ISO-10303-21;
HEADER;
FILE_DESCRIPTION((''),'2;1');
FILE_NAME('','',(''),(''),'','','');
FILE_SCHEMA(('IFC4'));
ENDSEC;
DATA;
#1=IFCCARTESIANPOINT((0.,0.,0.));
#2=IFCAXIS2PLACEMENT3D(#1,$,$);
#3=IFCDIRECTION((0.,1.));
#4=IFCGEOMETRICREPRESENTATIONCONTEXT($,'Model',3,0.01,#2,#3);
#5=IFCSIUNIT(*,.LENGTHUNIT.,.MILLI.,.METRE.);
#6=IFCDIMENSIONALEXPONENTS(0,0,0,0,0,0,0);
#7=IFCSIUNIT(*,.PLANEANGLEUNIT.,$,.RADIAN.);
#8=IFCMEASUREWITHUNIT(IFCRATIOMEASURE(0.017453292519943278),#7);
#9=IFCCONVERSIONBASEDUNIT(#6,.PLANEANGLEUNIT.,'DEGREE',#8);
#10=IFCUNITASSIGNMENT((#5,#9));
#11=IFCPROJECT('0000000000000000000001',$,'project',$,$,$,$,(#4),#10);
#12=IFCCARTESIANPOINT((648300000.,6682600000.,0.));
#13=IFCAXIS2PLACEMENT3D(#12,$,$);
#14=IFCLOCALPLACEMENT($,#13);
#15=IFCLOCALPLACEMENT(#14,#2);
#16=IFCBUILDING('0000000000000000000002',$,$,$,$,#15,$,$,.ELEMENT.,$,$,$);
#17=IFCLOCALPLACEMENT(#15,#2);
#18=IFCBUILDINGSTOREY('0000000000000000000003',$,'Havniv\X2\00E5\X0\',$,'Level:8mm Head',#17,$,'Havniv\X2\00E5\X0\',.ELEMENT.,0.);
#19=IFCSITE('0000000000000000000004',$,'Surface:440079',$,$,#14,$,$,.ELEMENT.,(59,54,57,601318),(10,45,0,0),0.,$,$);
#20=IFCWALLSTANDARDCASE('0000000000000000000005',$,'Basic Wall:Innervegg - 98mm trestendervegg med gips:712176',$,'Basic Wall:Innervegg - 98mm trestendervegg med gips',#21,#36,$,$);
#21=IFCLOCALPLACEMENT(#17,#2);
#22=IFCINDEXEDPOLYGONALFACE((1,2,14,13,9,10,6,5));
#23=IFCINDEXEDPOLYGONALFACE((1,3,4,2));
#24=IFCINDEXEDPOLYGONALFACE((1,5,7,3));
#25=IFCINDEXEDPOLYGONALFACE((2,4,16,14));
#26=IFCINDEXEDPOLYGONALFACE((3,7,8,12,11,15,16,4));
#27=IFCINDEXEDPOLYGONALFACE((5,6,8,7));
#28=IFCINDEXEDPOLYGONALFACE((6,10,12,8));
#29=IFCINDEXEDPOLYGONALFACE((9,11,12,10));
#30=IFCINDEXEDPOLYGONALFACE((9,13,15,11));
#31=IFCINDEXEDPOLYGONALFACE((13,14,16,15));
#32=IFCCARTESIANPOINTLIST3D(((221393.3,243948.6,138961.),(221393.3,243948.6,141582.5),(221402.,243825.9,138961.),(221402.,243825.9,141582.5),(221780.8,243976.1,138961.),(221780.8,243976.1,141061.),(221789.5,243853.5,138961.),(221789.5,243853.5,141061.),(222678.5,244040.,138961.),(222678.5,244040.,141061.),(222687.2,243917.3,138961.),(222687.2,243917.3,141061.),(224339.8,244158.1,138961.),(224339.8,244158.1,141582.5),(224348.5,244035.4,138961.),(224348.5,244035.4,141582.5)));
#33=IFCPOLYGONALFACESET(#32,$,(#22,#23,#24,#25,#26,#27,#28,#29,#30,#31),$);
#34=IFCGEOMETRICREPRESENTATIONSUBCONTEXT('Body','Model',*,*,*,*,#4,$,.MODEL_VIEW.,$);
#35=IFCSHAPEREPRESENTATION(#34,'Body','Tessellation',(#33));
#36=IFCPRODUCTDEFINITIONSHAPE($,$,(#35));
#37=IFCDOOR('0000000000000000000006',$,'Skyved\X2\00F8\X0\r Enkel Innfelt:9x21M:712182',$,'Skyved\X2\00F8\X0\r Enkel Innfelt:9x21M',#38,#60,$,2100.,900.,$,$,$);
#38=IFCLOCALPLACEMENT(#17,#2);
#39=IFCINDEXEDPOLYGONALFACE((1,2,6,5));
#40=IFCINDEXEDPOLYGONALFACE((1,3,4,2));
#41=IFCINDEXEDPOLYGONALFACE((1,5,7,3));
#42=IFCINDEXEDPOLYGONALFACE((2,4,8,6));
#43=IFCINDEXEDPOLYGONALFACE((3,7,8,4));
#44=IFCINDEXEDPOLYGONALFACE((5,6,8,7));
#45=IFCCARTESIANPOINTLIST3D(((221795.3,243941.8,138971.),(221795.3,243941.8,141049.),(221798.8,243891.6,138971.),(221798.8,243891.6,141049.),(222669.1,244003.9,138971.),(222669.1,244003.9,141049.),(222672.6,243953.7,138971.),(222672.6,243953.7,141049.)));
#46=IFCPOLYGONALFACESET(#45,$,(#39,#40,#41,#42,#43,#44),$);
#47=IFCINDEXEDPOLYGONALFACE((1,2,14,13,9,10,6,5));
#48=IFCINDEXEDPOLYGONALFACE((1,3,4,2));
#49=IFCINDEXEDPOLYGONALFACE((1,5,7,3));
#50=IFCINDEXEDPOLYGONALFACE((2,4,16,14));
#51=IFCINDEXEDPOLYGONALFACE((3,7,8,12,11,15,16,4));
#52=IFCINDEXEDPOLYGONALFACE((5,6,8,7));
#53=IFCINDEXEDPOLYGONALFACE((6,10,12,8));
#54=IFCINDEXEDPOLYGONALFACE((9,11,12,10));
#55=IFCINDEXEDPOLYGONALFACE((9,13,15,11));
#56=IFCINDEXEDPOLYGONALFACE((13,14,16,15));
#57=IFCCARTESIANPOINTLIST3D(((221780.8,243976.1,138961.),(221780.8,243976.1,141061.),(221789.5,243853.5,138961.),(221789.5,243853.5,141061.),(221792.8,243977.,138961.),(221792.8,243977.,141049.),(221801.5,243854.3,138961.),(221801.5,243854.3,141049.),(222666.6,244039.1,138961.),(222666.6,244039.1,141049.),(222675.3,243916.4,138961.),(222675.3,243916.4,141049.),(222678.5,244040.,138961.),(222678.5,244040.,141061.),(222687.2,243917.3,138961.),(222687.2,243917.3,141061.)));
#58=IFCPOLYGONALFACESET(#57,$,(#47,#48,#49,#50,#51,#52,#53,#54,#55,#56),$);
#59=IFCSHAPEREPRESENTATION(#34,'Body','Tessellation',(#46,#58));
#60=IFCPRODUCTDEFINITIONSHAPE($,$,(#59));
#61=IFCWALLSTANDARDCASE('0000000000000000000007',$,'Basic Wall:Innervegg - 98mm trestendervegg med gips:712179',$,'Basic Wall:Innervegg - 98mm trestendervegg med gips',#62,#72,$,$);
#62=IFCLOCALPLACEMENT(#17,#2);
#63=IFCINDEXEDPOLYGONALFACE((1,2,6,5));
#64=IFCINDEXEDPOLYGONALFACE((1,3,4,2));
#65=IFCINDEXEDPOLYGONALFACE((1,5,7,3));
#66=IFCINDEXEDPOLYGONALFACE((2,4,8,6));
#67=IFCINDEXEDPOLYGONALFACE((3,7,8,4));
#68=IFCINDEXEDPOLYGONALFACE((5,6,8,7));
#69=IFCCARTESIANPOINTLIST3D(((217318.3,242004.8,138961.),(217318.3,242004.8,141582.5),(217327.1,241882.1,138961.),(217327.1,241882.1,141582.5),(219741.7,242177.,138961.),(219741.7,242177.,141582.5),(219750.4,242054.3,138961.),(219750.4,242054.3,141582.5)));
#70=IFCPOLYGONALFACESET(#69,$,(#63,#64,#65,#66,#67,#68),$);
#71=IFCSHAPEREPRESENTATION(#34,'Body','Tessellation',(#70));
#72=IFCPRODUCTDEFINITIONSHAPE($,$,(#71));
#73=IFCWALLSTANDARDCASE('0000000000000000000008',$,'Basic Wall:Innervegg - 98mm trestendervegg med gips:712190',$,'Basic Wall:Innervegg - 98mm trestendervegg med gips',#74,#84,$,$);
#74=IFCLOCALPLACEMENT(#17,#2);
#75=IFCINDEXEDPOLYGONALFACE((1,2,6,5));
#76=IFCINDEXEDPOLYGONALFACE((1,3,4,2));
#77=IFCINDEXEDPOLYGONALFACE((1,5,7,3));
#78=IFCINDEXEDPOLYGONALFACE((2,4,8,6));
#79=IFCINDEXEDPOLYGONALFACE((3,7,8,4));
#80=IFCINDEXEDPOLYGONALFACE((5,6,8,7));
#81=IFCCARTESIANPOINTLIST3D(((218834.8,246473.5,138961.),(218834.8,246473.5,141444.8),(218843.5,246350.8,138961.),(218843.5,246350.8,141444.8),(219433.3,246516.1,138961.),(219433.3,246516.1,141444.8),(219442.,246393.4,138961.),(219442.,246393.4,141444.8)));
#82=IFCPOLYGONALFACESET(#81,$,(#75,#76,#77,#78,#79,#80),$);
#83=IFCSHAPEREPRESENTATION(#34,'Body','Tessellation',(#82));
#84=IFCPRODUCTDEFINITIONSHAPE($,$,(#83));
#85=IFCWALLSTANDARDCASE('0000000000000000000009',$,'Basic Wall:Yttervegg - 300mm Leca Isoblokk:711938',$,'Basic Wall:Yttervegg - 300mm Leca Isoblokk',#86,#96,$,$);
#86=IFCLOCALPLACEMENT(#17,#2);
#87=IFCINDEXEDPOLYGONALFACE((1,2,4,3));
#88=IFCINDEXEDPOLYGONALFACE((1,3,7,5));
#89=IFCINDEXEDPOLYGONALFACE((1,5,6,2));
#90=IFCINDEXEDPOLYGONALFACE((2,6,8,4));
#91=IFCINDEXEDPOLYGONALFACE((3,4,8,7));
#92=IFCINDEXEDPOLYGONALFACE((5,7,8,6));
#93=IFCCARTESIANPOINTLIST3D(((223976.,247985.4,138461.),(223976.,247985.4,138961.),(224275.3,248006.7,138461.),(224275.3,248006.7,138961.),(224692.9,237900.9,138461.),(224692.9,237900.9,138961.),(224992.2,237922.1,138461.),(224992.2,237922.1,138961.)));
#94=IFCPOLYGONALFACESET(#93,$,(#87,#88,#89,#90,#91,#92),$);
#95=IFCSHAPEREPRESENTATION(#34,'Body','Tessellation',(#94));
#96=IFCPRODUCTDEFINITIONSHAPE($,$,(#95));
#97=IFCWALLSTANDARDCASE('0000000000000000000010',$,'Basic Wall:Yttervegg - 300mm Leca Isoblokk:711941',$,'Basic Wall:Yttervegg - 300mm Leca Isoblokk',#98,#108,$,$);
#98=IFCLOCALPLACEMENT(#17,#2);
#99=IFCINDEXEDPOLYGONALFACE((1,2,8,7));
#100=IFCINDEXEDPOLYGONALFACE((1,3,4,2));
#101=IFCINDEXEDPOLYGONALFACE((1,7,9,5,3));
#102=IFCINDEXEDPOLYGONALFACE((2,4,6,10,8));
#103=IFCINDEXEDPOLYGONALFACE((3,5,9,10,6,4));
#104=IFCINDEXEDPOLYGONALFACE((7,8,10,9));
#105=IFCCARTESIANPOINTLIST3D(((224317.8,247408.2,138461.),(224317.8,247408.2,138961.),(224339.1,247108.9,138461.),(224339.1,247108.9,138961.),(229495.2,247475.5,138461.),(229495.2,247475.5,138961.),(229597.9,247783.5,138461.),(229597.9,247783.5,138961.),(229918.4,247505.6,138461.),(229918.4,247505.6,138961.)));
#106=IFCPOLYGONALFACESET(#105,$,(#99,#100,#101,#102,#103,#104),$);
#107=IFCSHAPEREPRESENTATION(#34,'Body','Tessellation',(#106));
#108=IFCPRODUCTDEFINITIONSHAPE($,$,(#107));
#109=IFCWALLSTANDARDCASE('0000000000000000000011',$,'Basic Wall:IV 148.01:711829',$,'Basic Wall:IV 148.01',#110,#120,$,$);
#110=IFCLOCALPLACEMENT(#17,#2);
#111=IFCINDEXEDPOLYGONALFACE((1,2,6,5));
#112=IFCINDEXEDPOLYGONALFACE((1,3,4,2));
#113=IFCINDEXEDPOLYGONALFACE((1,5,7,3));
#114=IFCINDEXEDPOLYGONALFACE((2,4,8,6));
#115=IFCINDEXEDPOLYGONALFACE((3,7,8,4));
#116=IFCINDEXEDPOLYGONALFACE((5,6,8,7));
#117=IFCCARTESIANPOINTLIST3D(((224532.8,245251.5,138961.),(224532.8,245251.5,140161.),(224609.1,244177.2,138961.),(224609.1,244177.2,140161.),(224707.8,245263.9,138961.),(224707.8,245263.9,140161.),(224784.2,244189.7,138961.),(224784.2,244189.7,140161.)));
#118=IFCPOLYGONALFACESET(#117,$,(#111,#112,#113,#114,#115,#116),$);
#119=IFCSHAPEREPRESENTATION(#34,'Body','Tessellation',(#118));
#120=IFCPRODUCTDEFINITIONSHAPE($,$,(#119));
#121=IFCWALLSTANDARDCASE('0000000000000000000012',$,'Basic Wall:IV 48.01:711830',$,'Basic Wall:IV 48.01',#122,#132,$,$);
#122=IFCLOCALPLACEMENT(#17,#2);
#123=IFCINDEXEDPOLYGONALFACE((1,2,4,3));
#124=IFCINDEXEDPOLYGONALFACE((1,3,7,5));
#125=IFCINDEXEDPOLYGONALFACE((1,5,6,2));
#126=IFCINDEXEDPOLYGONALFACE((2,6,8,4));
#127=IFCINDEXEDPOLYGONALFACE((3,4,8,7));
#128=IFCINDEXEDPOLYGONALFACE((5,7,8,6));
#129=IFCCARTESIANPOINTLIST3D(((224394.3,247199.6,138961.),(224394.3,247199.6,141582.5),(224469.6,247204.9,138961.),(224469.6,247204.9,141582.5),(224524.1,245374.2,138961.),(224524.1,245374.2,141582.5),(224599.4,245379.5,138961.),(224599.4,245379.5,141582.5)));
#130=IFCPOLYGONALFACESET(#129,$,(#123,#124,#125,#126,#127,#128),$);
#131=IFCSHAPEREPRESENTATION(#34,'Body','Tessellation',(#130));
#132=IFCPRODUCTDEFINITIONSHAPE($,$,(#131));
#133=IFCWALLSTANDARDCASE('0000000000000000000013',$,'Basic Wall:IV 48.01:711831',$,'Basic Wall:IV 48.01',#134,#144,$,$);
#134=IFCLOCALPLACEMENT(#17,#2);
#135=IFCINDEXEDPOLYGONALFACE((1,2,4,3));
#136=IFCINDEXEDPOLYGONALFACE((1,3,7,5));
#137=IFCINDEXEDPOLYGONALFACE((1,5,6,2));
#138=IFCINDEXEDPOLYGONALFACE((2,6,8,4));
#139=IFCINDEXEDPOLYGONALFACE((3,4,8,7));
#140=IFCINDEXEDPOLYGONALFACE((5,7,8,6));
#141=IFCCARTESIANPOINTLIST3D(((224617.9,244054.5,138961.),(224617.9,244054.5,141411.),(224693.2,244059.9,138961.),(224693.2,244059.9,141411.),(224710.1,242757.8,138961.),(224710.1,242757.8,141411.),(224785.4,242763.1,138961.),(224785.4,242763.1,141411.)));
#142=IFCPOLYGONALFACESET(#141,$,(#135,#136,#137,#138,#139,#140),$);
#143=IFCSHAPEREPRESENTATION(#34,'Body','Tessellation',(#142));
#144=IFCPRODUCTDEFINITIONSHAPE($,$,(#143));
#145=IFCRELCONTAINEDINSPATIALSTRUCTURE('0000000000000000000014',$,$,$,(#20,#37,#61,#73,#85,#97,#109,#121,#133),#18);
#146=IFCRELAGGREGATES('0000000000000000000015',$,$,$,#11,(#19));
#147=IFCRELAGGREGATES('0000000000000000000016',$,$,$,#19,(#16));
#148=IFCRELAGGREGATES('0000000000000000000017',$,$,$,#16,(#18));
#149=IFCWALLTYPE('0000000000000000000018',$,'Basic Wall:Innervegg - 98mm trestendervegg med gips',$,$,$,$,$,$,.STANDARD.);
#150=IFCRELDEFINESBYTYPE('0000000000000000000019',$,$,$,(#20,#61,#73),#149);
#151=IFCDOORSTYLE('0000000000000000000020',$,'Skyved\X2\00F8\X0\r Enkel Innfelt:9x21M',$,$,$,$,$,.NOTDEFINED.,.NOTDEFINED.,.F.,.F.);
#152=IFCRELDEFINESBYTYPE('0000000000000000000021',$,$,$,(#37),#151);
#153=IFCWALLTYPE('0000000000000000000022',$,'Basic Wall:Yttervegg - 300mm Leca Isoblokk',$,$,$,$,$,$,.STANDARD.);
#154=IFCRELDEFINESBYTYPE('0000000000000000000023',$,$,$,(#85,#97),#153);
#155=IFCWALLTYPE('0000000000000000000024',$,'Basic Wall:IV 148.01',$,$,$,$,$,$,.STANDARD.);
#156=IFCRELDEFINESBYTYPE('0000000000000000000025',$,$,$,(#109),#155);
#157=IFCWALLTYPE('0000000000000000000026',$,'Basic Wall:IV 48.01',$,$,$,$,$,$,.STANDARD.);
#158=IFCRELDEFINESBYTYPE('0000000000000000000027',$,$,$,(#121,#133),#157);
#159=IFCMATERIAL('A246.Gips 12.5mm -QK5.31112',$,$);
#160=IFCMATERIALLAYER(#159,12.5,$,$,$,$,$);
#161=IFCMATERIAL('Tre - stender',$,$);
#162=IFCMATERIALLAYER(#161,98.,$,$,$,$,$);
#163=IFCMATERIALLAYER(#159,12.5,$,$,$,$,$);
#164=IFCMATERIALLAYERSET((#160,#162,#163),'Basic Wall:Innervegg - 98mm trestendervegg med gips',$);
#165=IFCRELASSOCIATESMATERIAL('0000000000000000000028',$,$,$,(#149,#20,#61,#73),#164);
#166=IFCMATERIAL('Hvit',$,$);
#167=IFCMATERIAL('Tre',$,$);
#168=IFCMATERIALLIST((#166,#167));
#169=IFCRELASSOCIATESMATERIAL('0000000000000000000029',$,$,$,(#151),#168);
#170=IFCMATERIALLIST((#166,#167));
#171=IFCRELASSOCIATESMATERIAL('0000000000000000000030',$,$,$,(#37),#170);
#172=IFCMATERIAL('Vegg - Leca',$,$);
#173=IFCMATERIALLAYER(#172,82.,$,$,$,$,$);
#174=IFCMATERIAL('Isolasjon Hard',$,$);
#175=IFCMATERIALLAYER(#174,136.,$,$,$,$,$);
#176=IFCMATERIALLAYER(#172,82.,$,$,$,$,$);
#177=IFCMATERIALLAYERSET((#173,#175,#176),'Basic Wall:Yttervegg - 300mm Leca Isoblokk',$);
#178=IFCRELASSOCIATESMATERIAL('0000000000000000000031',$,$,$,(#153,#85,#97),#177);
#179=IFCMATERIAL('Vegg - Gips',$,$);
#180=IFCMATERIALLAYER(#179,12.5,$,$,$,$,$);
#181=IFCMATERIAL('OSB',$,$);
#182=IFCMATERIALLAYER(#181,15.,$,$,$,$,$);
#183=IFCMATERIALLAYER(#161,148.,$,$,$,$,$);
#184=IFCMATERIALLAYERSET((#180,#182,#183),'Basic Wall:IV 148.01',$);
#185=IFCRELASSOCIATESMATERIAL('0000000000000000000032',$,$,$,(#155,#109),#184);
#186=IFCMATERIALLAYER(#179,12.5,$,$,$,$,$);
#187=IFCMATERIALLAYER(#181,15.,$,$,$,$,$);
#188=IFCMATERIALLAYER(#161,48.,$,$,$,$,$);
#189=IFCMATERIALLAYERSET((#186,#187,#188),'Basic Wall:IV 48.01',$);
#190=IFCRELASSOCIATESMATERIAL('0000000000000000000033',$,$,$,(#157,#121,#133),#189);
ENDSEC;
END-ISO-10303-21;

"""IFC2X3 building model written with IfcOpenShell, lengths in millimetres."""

from ifc_helpers import new_model, entity, si_unit, converted_unit, direction, frame, frame_2d, origin, place, context, subcontext, project, spatial, polyline, rectangle, outline, extrude, clip, bounded_halfspace, source, transform, mapped, material, material_list, layer, layer_set, layer_usage, type_object, type_shapes, element, fill, save


model = new_model("IFC2X3")

# Units and contexts
model_context = context("Model", 3, precision=0.01, world=origin(), true_north=direction((0.0, 1.0)))
body_context = subcontext(model_context, "Body", "Model", "MODEL_VIEW")
ifc_project = project(units=[si_unit("LENGTHUNIT", "METRE", prefix="MILLI"), converted_unit("PLANEANGLEUNIT", "DEGREE", entity("IfcRatioMeasure", 0.017453292519943278), si_unit("PLANEANGLEUNIT", "RADIAN"), dimensions=[0, 0, 0, 0, 0, 0, 0])], contexts=[model_context])

# Site, building, storey
site_placement = place(None, frame((648300000.0, 6682600000.0, 0.0)))
site = spatial("IfcSite", under=ifc_project, at=site_placement, Name="Surface:440079", CompositionType="ELEMENT", RefLatitude=(59, 54, 57, 601318), RefLongitude=(10, 45, 0, 0), RefElevation=0.0)
building_placement = place(site_placement, origin())
building = spatial("IfcBuilding", under=site, at=building_placement, CompositionType="ELEMENT")
storey_placement = place(building_placement, origin())
storey = spatial("IfcBuildingStorey", under=building, at=storey_placement, Name="Havnivå", ObjectType="Level:8mm Head", LongName="Havnivå", CompositionType="ELEMENT", Elevation=0.0)

# Shared definitions
ifc_material_1 = material(Name="Vegg - Gips")
ifc_material_2 = material(Name="A246.Gips 12.5mm -QK5.31112")
ifc_layer_1 = layer(ifc_material_2, 12.5)
ifc_material_3 = material(Name="Tre - stender")
ifc_layer_2 = layer(ifc_material_3, 98.0)
ifc_layer_3 = layer(ifc_material_2, 12.5)
ifc_layer_set_1 = layer_set([ifc_layer_1, ifc_layer_2, ifc_layer_3], Name="Basic Wall:Innervegg - 98mm trestendervegg med gips")
wall_type_1 = type_object("IfcWallType", Name="Basic Wall:Innervegg - 98mm trestendervegg med gips", PredefinedType="STANDARD", material=ifc_layer_set_1)

# Shared definitions
ifc_material_4 = material(Name="Hvit")
ifc_material_5 = material(Name="Tre")

# Wall, opening, door
ifc_layer_usage_1 = layer_usage(ifc_layer_set_1, "AXIS2", "POSITIVE", -61.5)
wall_1_placement = place(storey_placement, frame((221397.6, 243887.3, 138961.0), z_axis=(0.0, 0.0, 1.0), x_axis=(0.997483, 0.070908, 0.0)))
wall_1 = element("IfcWallStandardCase", 1, at=wall_1_placement, inside=storey, type_object=wall_type_1, material=ifc_layer_usage_1, Name="Basic Wall:Innervegg - 98mm trestendervegg med gips:712176", ObjectType="Basic Wall:Innervegg - 98mm trestendervegg med gips", context=body_context, shape_type="SweptSolid", body=[
    extrude(rectangle(XDim=2954.0, YDim=123.0, at=frame_2d((1477.0, 0.0), x_axis=(1.0, 0.0))), origin(), (0.0, 0.0, 1.0), 2621.5),
])
opening_1_placement = place(wall_1_placement, frame((388.5, -61.5, 0.0)))
opening_1 = element("IfcOpeningElement", 2, at=opening_1_placement, cuts=wall_1, ObjectType="Opening", context=body_context, shape_type="SweptSolid", body=[
    extrude(rectangle(XDim=2100.0, YDim=900.0, at=frame_2d((1050.0, 450.0), x_axis=(1.0, 0.0))), frame((0.0, 0.0, 0.0), z_axis=(0.0, 1.0, 0.0), x_axis=(0.0, 0.0, 1.0)), (0.0, 0.0, 1.0), 123.0),
])
ifc_material_list_1 = material_list([ifc_material_4, ifc_material_5])
ifc_material_list_2 = material_list([ifc_material_4, ifc_material_5])
door_style_1 = type_object("IfcDoorStyle", Name="Skyvedør Enkel Innfelt:9x21M", ConstructionType="NOTDEFINED", OperationType="NOTDEFINED", ParameterTakesPrecedence=False, Sizeable=False, material=ifc_material_list_2)
shared_shape_1 = source(origin(), body_context, "Body", "SweptSolid", [
    extrude(rectangle(XDim=50.4, YDim=876.0, at=frame_2d((0.0, 0.0), x_axis=(1.0, 0.0))), frame((450.0, 60.5, 10.0), z_axis=(0.0, 0.0, 1.0), x_axis=(0.0, -1.0, 0.0)), (0.0, 0.0, 1.0), 2078.0),
    extrude(outline(polyline([(-450.0, -1047.0), (-438.0, -1047.0), (-438.0, 1041.0), (438.0, 1041.0), (438.0, -1047.0), (450.0, -1047.0), (450.0, 1053.0), (-450.0, 1053.0), (-450.0, -1047.0)])), frame((450.0, 120.9, 1047.0), z_axis=(0.0, -1.0, 0.0), x_axis=(1.0, 0.0, 0.0)), (0.0, 0.0, 1.0), 123.0),
])
type_shapes(door_style_1, [shared_shape_1])
door_1_placement = place(opening_1_placement, frame((0.0, 2.1, 0.0)))
door_1 = element("IfcDoor", 3, at=door_1_placement, inside=storey, type_object=door_style_1, material=ifc_material_list_1, Name="Skyvedør Enkel Innfelt:9x21M:712182", ObjectType="Skyvedør Enkel Innfelt:9x21M", OverallHeight=2100.0, OverallWidth=900.0, context=body_context, shape_type="MappedRepresentation", body=[
    mapped(shared_shape_1, transform((0.0, 0.0, 0.0), scale=1.0)),
])
fill(opening_1, door_1)

# Walls
ifc_layer_usage_2 = layer_usage(ifc_layer_set_1, "AXIS2", "NEGATIVE", 61.5)
wall_2_placement = place(storey_placement, frame((219746.1, 242115.7, 138961.0), z_axis=(0.0, 0.0, 1.0), x_axis=(-0.997483, -0.070908, 0.0)))
element("IfcWallStandardCase", 4, at=wall_2_placement, inside=storey, type_object=wall_type_1, material=ifc_layer_usage_2, Name="Basic Wall:Innervegg - 98mm trestendervegg med gips:712179", ObjectType="Basic Wall:Innervegg - 98mm trestendervegg med gips", context=body_context, shape_type="SweptSolid", body=[
    extrude(rectangle(XDim=2429.5, YDim=123.0, at=frame_2d((1214.8, 0.0), x_axis=(-1.0, 0.0))), origin(), (0.0, 0.0, 1.0), 2621.5),
])
ifc_layer_usage_3 = layer_usage(ifc_layer_set_1, "AXIS2", "POSITIVE", -61.5)
wall_3_placement = place(storey_placement, frame((219437.6, 246454.7, 138961.0), z_axis=(0.0, 0.0, 1.0), x_axis=(-0.997483, -0.070908, 0.0)))
element("IfcWallStandardCase", 5, at=wall_3_placement, inside=storey, type_object=wall_type_1, material=ifc_layer_usage_3, Name="Basic Wall:Innervegg - 98mm trestendervegg med gips:712190", ObjectType="Basic Wall:Innervegg - 98mm trestendervegg med gips", context=body_context, shape_type="SweptSolid", body=[
    extrude(rectangle(XDim=600.0, YDim=123.0, at=frame_2d((300.0, 0.0), x_axis=(-1.0, 0.0))), origin(), (0.0, 0.0, 1.0), 2483.8),
])
ifc_material_6 = material(Name="Vegg - Leca")
ifc_layer_4 = layer(ifc_material_6, 82.0)
ifc_material_7 = material(Name="Isolasjon Hard")
ifc_layer_5 = layer(ifc_material_7, 136.0)
ifc_layer_6 = layer(ifc_material_6, 82.0)
ifc_layer_set_2 = layer_set([ifc_layer_4, ifc_layer_5, ifc_layer_6], Name="Basic Wall:Yttervegg - 300mm Leca Isoblokk")
ifc_layer_usage_4 = layer_usage(ifc_layer_set_2, "AXIS2", "NEGATIVE", 150.0)
wall_type_2 = type_object("IfcWallType", Name="Basic Wall:Yttervegg - 300mm Leca Isoblokk", PredefinedType="STANDARD", material=ifc_layer_set_2)
wall_4_placement = place(storey_placement, frame((224125.6, 247996.0, 138461.0), z_axis=(0.0, 0.0, 1.0), x_axis=(0.070908, -0.997483, 0.0)))
element("IfcWallStandardCase", 6, at=wall_4_placement, inside=storey, type_object=wall_type_2, material=ifc_layer_usage_4, Name="Basic Wall:Yttervegg - 300mm Leca Isoblokk:711938", ObjectType="Basic Wall:Yttervegg - 300mm Leca Isoblokk", context=body_context, shape_type="SweptSolid", body=[
    extrude(rectangle(XDim=10110.0, YDim=300.0, at=frame_2d((5055.0, 0.0), x_axis=(-1.0, 0.0))), origin(), (0.0, 0.0, 1.0), 500.0),
])
ifc_layer_usage_5 = layer_usage(ifc_layer_set_2, "AXIS2", "NEGATIVE", 150.0)
wall_5_placement = place(storey_placement, frame((224328.4, 247258.6, 138461.0), z_axis=(0.0, 0.0, 1.0), x_axis=(0.997483, 0.070908, 0.0)))
element("IfcWallStandardCase", 7, at=wall_5_placement, inside=storey, type_object=wall_type_2, material=ifc_layer_usage_5, Name="Basic Wall:Yttervegg - 300mm Leca Isoblokk:711941", ObjectType="Basic Wall:Yttervegg - 300mm Leca Isoblokk", context=body_context, shape_type="SweptSolid", body=[
    extrude(outline(polyline([(5593.4, -150.0), (5293.4, 150.0), (0.0, 150.0), (0.0, -150.0), (5169.1, -150.0), (5593.4, -150.0)])), origin(), (0.0, 0.0, 1.0), 500.0),
])
ifc_layer_7 = layer(ifc_material_1, 12.5)
ifc_material_8 = material(Name="OSB")
ifc_layer_8 = layer(ifc_material_8, 15.0)
ifc_layer_9 = layer(ifc_material_3, 148.0)
ifc_layer_set_3 = layer_set([ifc_layer_7, ifc_layer_8, ifc_layer_9], Name="Basic Wall:IV 148.01")
ifc_layer_usage_6 = layer_usage(ifc_layer_set_3, "AXIS2", "POSITIVE", -87.8)
wall_type_3 = type_object("IfcWallType", Name="Basic Wall:IV 148.01", PredefinedType="STANDARD", material=ifc_layer_set_3)
wall_6_placement = place(storey_placement, frame((224696.7, 244183.4, 138961.0), z_axis=(0.0, 0.0, 1.0), x_axis=(-0.070908, 0.997483, 0.0)))
element("IfcWallStandardCase", 8, at=wall_6_placement, inside=storey, type_object=wall_type_3, material=ifc_layer_usage_6, Name="Basic Wall:IV 148.01:711829", ObjectType="Basic Wall:IV 148.01", context=body_context, shape_type="SweptSolid", body=[
    extrude(rectangle(XDim=1077.0, YDim=175.5, at=frame_2d((538.5, 0.0), x_axis=(-1.0, 0.0))), origin(), (0.0, 0.0, 1.0), 1200.0),
])
ifc_layer_10 = layer(ifc_material_1, 12.5)
ifc_layer_11 = layer(ifc_material_8, 15.0)
ifc_layer_12 = layer(ifc_material_3, 48.0)
ifc_layer_set_4 = layer_set([ifc_layer_10, ifc_layer_11, ifc_layer_12], Name="Basic Wall:IV 48.01")
ifc_layer_usage_7 = layer_usage(ifc_layer_set_4, "AXIS2", "POSITIVE", -37.8)
wall_type_4 = type_object("IfcWallType", Name="Basic Wall:IV 48.01", PredefinedType="STANDARD", material=ifc_layer_set_4)
wall_7_placement = place(storey_placement, frame((224561.7, 245376.9, 138961.0), z_axis=(0.0, 0.0, 1.0), x_axis=(-0.070908, 0.997483, 0.0)))
element("IfcWallStandardCase", 9, at=wall_7_placement, inside=storey, type_object=wall_type_4, material=ifc_layer_usage_7, Name="Basic Wall:IV 48.01:711830", ObjectType="Basic Wall:IV 48.01", context=body_context, shape_type="Clipping", body=[
    clip(extrude(rectangle(XDim=1830.0, YDim=75.5, at=frame_2d((915.0, 0.0), x_axis=(-1.0, 0.0))), origin(), (0.0, 0.0, 1.0), 2621.5), bounded_halfspace(frame((0.0, -37.8, 2621.5), z_axis=(0.0, 0.0, -1.0), x_axis=(0.0, -1.0, 0.0)), True, frame((0.0, -37.8, 2621.5)), polyline([(0.0, 0.0), (557784.0, 0.0), (557784.0, 23012.4), (0.0, 23012.4), (0.0, 0.0)]))),
])
ifc_layer_usage_8 = layer_usage(ifc_layer_set_4, "AXIS2", "NEGATIVE", 37.8)
wall_8_placement = place(storey_placement, frame((224655.5, 244057.2, 138961.0), z_axis=(0.0, 0.0, 1.0), x_axis=(0.070908, -0.997483, 0.0)))
element("IfcWallStandardCase", 10, at=wall_8_placement, inside=storey, type_object=wall_type_4, material=ifc_layer_usage_8, Name="Basic Wall:IV 48.01:711831", ObjectType="Basic Wall:IV 48.01", context=body_context, shape_type="SweptSolid", body=[
    extrude(rectangle(XDim=1300.0, YDim=75.5, at=frame_2d((650.0, 0.0), x_axis=(-1.0, 0.0))), origin(), (0.0, 0.0, 1.0), 2450.0),
])

save(model, "model.ifc")
